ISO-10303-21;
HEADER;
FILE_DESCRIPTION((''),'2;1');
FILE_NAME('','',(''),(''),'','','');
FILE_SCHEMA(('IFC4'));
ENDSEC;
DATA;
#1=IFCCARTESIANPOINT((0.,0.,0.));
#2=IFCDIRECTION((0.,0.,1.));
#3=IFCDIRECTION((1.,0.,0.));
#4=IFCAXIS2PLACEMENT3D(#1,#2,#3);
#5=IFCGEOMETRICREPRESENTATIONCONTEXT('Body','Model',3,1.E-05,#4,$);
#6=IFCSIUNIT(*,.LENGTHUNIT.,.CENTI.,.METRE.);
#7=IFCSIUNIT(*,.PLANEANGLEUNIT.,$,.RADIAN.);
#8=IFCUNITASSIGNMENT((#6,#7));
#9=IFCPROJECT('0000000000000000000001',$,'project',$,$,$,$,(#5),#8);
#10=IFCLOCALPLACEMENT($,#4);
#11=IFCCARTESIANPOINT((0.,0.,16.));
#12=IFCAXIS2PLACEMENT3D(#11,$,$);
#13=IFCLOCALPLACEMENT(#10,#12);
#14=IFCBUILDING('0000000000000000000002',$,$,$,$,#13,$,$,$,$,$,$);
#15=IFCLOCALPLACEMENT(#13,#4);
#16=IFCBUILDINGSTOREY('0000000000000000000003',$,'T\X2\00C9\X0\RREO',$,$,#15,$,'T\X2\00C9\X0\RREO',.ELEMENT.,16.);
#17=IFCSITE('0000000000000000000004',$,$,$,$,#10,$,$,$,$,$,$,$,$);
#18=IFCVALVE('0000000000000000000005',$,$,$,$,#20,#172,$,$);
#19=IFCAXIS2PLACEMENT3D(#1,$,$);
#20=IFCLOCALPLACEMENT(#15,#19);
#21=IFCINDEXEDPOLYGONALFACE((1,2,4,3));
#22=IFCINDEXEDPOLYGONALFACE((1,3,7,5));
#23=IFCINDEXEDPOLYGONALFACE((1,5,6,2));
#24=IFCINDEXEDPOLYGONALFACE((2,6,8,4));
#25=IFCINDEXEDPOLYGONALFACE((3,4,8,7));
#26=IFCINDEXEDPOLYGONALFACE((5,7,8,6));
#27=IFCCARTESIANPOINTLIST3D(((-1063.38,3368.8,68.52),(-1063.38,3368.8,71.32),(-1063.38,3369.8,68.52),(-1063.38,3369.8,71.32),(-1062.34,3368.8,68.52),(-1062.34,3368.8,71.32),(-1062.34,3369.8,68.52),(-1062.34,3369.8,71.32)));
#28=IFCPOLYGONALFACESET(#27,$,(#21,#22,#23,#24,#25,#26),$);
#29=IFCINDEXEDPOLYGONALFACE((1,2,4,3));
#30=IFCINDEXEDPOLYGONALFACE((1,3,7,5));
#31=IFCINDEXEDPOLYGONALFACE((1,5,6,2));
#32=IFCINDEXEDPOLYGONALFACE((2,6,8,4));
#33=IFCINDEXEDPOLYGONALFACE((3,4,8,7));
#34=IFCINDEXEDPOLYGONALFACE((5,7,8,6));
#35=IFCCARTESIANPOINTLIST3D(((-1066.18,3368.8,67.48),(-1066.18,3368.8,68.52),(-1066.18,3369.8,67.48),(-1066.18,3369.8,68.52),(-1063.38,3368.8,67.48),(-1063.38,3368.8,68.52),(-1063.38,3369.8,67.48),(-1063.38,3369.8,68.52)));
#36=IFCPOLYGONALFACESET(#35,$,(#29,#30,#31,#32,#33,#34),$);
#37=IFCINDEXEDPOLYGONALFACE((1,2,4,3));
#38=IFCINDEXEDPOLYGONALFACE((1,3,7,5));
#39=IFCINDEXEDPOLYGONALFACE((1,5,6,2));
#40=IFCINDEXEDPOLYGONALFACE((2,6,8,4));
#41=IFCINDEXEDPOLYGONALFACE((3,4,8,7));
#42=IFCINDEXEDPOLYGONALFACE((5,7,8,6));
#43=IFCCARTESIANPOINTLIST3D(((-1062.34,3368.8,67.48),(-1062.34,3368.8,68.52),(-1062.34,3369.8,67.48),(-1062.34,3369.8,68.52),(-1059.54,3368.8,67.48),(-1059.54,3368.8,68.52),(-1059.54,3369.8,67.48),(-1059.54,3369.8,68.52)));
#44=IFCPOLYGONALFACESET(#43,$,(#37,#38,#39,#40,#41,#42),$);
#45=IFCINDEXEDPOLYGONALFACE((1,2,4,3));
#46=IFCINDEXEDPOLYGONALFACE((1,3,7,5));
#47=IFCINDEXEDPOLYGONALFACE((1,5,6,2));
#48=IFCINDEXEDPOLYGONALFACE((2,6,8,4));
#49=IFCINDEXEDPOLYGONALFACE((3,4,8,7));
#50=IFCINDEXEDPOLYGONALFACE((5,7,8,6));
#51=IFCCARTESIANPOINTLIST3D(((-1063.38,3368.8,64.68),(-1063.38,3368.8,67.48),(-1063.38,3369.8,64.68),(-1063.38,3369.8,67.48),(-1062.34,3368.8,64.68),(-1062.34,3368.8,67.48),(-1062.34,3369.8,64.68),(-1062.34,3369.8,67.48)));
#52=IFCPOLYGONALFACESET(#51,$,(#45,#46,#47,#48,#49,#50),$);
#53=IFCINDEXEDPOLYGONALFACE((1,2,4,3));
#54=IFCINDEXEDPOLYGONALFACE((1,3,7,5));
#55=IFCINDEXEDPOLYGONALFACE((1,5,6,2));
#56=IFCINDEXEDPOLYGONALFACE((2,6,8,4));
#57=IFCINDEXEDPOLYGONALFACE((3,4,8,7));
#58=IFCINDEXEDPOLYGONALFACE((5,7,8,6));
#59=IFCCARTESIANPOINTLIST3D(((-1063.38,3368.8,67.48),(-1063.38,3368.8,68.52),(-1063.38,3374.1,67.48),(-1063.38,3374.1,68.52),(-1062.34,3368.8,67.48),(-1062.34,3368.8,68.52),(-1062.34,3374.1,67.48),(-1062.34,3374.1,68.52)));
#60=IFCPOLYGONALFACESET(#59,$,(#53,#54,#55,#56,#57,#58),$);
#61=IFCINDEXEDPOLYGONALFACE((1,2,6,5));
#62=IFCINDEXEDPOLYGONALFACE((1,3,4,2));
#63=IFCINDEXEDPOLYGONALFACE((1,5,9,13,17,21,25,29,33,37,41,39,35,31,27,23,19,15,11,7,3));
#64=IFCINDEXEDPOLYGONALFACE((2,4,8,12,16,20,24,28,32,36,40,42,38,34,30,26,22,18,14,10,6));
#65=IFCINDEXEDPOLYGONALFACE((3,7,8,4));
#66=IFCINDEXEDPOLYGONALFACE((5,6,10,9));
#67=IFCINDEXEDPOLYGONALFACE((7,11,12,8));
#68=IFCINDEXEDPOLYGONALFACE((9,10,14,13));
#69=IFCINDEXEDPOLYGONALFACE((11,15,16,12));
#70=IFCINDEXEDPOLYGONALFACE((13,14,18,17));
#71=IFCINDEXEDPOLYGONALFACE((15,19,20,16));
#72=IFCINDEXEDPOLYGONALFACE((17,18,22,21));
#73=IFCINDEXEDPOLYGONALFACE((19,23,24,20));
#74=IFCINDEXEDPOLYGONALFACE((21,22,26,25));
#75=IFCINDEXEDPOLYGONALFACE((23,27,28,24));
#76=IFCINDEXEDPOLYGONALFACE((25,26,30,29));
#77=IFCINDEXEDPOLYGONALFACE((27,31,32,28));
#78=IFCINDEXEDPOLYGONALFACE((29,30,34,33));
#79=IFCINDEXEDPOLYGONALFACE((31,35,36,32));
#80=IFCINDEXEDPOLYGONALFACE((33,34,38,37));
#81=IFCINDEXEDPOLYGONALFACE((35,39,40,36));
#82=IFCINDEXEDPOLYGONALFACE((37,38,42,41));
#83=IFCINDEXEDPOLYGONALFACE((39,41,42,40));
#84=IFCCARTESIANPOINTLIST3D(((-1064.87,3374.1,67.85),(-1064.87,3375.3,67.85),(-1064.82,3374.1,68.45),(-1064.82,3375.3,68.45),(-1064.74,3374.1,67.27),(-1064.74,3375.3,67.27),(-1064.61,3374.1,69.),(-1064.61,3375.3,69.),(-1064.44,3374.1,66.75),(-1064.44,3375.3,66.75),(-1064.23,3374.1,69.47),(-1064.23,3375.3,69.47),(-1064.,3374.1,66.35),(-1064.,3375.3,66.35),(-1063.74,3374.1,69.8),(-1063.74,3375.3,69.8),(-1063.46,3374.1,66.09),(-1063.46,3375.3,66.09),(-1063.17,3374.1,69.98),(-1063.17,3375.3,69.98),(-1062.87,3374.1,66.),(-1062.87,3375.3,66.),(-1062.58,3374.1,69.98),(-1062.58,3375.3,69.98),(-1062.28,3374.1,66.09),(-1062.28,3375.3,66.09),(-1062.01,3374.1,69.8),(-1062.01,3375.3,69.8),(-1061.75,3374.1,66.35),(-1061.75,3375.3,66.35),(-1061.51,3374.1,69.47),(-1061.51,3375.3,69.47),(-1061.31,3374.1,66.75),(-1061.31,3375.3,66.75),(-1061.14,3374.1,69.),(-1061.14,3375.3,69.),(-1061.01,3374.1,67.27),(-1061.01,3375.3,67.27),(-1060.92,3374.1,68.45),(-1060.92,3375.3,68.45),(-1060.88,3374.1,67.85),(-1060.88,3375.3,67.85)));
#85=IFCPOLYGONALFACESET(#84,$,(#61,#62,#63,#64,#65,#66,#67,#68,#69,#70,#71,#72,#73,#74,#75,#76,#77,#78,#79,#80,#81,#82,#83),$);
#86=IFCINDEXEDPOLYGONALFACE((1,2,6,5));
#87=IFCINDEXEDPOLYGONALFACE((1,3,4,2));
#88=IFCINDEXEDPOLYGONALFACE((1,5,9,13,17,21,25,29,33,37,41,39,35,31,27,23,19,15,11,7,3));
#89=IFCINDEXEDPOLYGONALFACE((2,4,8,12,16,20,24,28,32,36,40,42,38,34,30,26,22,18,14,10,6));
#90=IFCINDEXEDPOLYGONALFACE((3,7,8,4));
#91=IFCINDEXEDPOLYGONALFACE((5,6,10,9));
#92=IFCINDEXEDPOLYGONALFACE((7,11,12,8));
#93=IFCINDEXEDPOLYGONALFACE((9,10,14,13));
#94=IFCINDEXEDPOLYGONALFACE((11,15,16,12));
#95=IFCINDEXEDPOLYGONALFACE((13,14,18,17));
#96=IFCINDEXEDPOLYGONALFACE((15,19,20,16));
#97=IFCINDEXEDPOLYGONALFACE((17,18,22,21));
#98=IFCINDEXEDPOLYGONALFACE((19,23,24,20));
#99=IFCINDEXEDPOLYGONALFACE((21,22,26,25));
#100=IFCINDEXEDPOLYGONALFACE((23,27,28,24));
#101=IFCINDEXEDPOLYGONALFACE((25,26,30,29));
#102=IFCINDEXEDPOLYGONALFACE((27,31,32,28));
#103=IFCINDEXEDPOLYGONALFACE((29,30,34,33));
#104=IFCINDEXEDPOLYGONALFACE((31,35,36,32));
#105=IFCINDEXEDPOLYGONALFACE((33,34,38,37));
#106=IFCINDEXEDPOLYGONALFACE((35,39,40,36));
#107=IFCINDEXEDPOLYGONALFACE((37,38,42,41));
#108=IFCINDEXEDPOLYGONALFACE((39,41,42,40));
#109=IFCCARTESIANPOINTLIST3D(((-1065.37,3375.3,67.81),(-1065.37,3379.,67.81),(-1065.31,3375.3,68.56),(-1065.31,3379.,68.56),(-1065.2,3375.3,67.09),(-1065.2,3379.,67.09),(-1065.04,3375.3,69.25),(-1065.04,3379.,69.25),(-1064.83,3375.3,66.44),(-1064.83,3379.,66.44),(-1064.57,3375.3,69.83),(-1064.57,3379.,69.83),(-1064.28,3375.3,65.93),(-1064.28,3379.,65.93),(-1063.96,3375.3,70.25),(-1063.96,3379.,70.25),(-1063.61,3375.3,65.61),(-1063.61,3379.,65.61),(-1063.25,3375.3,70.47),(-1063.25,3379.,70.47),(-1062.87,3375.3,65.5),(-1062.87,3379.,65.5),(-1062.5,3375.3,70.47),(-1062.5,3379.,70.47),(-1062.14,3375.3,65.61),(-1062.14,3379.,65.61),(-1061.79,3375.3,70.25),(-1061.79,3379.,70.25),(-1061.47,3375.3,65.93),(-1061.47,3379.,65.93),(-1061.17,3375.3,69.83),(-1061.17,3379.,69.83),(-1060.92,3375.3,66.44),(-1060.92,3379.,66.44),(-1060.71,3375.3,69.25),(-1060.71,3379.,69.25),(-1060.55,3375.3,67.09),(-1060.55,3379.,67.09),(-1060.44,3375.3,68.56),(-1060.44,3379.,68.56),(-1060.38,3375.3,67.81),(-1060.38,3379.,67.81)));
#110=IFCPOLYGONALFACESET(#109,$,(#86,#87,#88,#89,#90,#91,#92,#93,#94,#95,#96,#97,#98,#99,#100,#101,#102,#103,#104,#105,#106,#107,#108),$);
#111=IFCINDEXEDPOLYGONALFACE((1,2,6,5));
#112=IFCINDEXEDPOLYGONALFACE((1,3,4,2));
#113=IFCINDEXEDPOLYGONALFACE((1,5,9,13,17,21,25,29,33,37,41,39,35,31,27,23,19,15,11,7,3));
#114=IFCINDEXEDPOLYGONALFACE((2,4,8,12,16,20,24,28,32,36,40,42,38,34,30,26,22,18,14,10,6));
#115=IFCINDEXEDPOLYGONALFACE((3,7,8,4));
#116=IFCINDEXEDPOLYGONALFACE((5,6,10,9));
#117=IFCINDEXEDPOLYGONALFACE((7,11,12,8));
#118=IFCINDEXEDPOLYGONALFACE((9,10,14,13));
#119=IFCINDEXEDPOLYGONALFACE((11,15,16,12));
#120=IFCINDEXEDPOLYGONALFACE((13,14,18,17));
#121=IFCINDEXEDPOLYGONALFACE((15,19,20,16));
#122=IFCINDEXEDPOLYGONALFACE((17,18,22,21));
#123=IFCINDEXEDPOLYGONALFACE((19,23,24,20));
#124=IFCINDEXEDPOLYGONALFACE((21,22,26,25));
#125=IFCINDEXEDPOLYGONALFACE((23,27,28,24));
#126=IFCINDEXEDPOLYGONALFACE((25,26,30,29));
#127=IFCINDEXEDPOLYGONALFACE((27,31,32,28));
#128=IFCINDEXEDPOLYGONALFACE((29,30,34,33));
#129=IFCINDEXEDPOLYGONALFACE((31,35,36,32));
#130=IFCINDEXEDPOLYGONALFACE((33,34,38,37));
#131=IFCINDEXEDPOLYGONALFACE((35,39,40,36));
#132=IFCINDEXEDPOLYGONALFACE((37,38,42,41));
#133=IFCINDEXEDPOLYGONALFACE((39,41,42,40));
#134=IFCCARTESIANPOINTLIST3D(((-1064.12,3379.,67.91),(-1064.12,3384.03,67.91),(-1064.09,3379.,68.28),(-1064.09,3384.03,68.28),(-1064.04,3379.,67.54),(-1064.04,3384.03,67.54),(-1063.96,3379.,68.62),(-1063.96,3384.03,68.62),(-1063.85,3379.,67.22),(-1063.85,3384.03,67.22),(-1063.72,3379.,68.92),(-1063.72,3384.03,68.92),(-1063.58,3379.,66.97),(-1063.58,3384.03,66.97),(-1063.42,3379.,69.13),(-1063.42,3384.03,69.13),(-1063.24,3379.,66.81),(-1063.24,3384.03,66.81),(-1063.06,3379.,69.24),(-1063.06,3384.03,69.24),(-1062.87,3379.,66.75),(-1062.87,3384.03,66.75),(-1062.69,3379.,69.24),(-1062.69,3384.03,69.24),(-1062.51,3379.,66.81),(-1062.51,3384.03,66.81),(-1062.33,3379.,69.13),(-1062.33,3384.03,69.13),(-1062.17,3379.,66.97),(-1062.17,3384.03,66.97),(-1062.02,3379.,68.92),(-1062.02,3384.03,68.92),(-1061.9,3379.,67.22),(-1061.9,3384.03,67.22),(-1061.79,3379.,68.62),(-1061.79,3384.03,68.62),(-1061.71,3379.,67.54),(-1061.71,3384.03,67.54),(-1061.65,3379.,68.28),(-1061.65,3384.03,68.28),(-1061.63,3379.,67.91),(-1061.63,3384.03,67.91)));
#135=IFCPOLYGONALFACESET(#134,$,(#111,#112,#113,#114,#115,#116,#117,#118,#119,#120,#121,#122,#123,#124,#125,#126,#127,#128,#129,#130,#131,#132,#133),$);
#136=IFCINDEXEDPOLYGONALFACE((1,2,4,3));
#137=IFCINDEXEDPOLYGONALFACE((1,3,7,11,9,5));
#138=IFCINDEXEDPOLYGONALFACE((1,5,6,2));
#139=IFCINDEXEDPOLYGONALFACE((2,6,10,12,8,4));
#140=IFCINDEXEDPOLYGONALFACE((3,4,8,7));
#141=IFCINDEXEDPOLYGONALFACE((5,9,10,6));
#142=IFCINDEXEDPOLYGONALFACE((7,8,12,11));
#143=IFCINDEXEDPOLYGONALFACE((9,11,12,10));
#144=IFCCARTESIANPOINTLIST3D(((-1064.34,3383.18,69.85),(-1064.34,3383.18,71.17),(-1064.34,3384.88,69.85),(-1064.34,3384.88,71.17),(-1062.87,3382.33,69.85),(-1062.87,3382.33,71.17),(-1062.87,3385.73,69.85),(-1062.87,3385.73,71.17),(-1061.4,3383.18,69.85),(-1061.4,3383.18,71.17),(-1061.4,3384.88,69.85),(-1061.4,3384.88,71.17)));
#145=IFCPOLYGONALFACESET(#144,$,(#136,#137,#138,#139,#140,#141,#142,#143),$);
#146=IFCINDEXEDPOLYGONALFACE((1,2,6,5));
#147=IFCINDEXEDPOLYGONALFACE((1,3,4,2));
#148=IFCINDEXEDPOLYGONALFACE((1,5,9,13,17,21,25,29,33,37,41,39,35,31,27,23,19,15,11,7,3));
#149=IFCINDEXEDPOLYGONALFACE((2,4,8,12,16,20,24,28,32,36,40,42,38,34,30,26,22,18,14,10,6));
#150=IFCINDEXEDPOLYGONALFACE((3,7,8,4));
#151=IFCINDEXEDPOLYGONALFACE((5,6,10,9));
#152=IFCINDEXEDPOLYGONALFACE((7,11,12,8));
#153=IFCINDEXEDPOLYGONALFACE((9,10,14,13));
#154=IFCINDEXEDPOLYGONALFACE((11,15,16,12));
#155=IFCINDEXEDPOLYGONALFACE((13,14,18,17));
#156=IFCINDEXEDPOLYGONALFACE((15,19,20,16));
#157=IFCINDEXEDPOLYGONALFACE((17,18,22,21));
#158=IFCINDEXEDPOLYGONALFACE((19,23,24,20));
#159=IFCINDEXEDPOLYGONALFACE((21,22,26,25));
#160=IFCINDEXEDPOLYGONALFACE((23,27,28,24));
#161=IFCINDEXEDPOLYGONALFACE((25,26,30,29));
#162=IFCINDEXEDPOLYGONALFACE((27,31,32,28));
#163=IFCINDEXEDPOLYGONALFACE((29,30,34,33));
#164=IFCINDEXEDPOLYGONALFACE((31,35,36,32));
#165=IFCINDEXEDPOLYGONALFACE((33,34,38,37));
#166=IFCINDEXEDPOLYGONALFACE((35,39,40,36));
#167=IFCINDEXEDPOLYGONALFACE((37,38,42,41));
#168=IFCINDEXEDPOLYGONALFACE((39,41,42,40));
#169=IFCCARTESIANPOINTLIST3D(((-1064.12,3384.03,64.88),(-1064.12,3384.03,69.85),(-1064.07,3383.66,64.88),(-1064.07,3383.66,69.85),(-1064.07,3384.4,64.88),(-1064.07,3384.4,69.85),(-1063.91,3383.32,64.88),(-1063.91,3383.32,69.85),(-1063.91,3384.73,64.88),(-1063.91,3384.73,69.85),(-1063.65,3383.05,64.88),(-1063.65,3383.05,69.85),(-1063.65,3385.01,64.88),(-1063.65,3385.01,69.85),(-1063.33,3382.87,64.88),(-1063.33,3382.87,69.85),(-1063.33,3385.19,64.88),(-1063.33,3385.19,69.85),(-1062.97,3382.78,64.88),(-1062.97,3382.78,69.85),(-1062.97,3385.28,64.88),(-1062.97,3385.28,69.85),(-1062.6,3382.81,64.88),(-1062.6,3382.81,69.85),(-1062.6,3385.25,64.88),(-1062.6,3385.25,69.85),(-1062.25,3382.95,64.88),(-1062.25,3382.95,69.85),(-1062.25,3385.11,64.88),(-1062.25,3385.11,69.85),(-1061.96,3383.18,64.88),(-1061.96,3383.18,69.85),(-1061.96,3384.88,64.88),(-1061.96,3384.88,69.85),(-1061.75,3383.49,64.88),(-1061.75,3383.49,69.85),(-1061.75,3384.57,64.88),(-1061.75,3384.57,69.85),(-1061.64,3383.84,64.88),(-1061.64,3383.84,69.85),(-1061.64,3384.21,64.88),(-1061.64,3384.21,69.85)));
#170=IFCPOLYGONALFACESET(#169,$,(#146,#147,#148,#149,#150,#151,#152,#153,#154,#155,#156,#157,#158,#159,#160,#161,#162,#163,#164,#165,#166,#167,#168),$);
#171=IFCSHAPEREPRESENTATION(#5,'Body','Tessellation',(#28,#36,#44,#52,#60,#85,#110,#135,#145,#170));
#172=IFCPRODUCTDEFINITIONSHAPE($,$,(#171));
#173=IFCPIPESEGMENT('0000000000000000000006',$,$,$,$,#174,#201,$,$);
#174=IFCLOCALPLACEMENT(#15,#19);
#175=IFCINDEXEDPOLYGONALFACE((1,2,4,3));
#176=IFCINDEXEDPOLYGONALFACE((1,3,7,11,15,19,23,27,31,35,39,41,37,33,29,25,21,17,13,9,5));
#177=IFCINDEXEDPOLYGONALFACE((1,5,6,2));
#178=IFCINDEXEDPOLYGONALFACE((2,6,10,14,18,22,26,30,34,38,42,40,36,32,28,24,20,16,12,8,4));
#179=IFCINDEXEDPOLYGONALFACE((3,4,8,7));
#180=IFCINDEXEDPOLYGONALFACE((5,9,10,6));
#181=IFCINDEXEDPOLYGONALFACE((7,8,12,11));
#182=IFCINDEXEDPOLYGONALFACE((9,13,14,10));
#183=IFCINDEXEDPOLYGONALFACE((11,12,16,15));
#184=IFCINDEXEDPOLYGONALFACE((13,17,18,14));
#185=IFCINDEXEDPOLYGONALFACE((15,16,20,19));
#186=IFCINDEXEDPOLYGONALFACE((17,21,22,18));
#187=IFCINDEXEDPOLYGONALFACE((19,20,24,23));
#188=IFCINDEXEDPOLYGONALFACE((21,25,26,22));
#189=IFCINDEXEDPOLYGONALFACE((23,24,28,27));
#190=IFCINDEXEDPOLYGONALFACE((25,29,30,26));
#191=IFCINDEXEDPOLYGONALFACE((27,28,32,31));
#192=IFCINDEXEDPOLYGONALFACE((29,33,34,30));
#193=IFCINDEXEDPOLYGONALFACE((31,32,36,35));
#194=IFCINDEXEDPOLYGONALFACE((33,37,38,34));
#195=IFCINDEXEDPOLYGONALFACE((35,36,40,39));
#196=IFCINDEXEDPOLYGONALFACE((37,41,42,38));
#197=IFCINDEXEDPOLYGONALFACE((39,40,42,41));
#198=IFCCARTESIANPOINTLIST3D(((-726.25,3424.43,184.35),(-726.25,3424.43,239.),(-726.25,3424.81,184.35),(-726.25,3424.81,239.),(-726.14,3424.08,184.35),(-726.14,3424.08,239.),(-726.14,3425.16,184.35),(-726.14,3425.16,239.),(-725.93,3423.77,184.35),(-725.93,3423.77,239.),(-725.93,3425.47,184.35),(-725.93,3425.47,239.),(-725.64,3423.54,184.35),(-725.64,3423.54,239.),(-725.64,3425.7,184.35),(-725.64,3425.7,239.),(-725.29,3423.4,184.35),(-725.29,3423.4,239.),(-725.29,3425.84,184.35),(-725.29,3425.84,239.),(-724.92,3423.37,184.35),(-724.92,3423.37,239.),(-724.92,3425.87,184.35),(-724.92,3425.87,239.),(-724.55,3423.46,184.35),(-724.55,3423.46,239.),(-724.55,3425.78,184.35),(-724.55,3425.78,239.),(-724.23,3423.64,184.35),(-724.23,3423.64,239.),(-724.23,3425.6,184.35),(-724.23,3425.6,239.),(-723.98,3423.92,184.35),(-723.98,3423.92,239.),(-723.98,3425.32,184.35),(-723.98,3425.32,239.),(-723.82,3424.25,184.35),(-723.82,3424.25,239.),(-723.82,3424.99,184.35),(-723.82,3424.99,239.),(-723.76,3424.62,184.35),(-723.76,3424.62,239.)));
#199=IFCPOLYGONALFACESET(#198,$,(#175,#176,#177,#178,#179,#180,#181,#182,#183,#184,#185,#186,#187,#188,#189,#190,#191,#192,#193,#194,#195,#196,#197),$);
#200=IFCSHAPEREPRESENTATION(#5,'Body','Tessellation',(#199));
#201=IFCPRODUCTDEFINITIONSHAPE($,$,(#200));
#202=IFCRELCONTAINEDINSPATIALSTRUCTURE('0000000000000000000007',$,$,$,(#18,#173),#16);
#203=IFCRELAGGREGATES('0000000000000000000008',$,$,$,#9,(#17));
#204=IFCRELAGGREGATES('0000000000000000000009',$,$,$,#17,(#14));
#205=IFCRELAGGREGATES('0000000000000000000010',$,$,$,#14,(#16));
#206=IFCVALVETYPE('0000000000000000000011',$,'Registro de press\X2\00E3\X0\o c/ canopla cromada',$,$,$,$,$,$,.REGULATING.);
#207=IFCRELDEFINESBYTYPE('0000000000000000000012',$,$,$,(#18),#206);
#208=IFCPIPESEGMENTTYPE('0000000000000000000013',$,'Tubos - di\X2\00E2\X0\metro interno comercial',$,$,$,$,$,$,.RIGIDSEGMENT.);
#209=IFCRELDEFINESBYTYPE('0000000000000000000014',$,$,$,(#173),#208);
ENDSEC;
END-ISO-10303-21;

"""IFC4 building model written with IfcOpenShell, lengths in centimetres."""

from ifc_helpers import new_model, si_unit, frame, origin_with_axes, origin_2d_with_axis, place, context, project, spatial, polyline, rectangle, circle, outline, extrude, source, transform, mapped, type_object, element, save


model = new_model("IFC4")

# Units and contexts
model_context = context("Model", 3, precision=1e-05, world=origin_with_axes(), identifier="Body")
ifc_project = project(units=[si_unit("LENGTHUNIT", "METRE", prefix="CENTI"), si_unit("PLANEANGLEUNIT", "RADIAN")], contexts=[model_context])

# Site, building, storey
site_placement = place(None, origin_with_axes())
site = spatial("IfcSite", under=ifc_project, at=site_placement)
building_placement = place(site_placement, frame((0.0, 0.0, 16.0)))
building = spatial("IfcBuilding", under=site, at=building_placement)
storey_placement = place(building_placement, origin_with_axes())
storey = spatial("IfcBuildingStorey", under=building, at=storey_placement, Name="TÉRREO", LongName="TÉRREO", CompositionType="ELEMENT", Elevation=16.0)

# Valve
valve_type = type_object("IfcValveType", Name="Registro de pressão c/ canopla cromada", PredefinedType="REGULATING")
shared_shape = source(origin_with_axes(), model_context, "Body", "SolidModel", [
    extrude(rectangle(XDim=1.04, YDim=2.8, at=origin_2d_with_axis()), frame((-1.92, 0.01, 14.22), z_axis=(0.0, 0.0, 1.0), x_axis=(0.0, -1.0, 0.0)), (0.0, 0.0, 1.0), 1.0),
    extrude(rectangle(XDim=1.04, YDim=2.8, at=origin_2d_with_axis()), frame((0.0, -1.91, 14.22), z_axis=(0.0, 0.0, 1.0), x_axis=(1.0, 0.0, 0.0)), (0.0, 0.0, 1.0), 1.0),
    extrude(rectangle(XDim=1.04, YDim=2.8, at=origin_2d_with_axis()), frame((0.0, 1.93, 14.22), z_axis=(0.0, 0.0, 1.0), x_axis=(-1.0, 0.0, 0.0)), (0.0, 0.0, 1.0), 1.0),
    extrude(rectangle(XDim=1.04, YDim=2.8, at=origin_2d_with_axis()), frame((1.92, 0.01, 14.22), z_axis=(0.0, 0.0, 1.0), x_axis=(0.0, 1.0, 0.0)), (0.0, 0.0, 1.0), 1.0),
    extrude(rectangle(XDim=1.04, YDim=1.04, at=origin_2d_with_axis()), frame((0.0, 0.01, 9.92), z_axis=(0.0, 0.0, 1.0), x_axis=(0.0, 1.0, 0.0)), (0.0, 0.0, 1.0), 5.3),
    extrude(circle(Radius=2.0, at=origin_2d_with_axis()), frame((0.0, 0.0, 8.72), z_axis=(0.0, 0.0, 1.0), x_axis=(1.0, 0.0, 0.0)), (0.0, 0.0, 1.0), 1.2),
    extrude(circle(Radius=2.5, at=origin_2d_with_axis()), frame((0.0, 0.0, 5.02), z_axis=(0.0, 0.0, 1.0), x_axis=(1.0, 0.0, 0.0)), (0.0, 0.0, 1.0), 3.7),
    extrude(circle(Radius=1.25, at=origin_2d_with_axis()), origin_with_axes(), (0.0, 0.0, 1.0), 5.02),
    extrude(outline(polyline([(-0.85, -1.47), (0.85, -1.47), (1.7, 0.0), (0.85, 1.47), (-0.85, 1.47), (-1.7, 0.0), (-0.85, -1.47)])), frame((-3.17, 0.0, 0.0), z_axis=(1.0, 0.0, 0.0), x_axis=(0.0, 0.0, -1.0)), (0.0, 0.0, 1.0), 1.32),
    extrude(circle(Radius=1.25, at=origin_2d_with_axis()), frame((-1.85, 0.0, 0.0), z_axis=(1.0, 0.0, 0.0), x_axis=(0.0, -1.0, 0.0)), (0.0, 0.0, 1.0), 4.97),
])
valve_placement = place(storey_placement, frame((-1062.87, 3384.03, 68.0), z_axis=(0.0, -1.0, 0.0), x_axis=(0.0, 0.0, -1.0)))
element("IfcValve", 1, at=valve_placement, inside=storey, type_object=valve_type, context=model_context, shape_type="MappedRepresentation", body=[
    mapped(shared_shape, transform((0.0, 0.0, 0.0), scale=1.0)),
])

# Pipe segment
pipe_segment_type = type_object("IfcPipeSegmentType", Name="Tubos - diâmetro interno comercial", PredefinedType="RIGIDSEGMENT")
pipe_segment_1_placement = place(storey_placement, frame((-725.01, 3424.62, 239.0), z_axis=(0.0, 0.0, 1.0), x_axis=(1.0, 0.0, 0.0)))
element("IfcPipeSegment", 2, at=pipe_segment_1_placement, inside=storey, type_object=pipe_segment_type, context=model_context, shape_type="SolidModel", body=[
    extrude(circle(Radius=1.25, at=origin_2d_with_axis()), frame((0.0, 0.0, 0.0), z_axis=(0.0, 0.0, -1.0), x_axis=(1.0, 0.0, 0.0)), (0.0, 0.0, 1.0), 54.65),
])

save(model, "model.ifc")
